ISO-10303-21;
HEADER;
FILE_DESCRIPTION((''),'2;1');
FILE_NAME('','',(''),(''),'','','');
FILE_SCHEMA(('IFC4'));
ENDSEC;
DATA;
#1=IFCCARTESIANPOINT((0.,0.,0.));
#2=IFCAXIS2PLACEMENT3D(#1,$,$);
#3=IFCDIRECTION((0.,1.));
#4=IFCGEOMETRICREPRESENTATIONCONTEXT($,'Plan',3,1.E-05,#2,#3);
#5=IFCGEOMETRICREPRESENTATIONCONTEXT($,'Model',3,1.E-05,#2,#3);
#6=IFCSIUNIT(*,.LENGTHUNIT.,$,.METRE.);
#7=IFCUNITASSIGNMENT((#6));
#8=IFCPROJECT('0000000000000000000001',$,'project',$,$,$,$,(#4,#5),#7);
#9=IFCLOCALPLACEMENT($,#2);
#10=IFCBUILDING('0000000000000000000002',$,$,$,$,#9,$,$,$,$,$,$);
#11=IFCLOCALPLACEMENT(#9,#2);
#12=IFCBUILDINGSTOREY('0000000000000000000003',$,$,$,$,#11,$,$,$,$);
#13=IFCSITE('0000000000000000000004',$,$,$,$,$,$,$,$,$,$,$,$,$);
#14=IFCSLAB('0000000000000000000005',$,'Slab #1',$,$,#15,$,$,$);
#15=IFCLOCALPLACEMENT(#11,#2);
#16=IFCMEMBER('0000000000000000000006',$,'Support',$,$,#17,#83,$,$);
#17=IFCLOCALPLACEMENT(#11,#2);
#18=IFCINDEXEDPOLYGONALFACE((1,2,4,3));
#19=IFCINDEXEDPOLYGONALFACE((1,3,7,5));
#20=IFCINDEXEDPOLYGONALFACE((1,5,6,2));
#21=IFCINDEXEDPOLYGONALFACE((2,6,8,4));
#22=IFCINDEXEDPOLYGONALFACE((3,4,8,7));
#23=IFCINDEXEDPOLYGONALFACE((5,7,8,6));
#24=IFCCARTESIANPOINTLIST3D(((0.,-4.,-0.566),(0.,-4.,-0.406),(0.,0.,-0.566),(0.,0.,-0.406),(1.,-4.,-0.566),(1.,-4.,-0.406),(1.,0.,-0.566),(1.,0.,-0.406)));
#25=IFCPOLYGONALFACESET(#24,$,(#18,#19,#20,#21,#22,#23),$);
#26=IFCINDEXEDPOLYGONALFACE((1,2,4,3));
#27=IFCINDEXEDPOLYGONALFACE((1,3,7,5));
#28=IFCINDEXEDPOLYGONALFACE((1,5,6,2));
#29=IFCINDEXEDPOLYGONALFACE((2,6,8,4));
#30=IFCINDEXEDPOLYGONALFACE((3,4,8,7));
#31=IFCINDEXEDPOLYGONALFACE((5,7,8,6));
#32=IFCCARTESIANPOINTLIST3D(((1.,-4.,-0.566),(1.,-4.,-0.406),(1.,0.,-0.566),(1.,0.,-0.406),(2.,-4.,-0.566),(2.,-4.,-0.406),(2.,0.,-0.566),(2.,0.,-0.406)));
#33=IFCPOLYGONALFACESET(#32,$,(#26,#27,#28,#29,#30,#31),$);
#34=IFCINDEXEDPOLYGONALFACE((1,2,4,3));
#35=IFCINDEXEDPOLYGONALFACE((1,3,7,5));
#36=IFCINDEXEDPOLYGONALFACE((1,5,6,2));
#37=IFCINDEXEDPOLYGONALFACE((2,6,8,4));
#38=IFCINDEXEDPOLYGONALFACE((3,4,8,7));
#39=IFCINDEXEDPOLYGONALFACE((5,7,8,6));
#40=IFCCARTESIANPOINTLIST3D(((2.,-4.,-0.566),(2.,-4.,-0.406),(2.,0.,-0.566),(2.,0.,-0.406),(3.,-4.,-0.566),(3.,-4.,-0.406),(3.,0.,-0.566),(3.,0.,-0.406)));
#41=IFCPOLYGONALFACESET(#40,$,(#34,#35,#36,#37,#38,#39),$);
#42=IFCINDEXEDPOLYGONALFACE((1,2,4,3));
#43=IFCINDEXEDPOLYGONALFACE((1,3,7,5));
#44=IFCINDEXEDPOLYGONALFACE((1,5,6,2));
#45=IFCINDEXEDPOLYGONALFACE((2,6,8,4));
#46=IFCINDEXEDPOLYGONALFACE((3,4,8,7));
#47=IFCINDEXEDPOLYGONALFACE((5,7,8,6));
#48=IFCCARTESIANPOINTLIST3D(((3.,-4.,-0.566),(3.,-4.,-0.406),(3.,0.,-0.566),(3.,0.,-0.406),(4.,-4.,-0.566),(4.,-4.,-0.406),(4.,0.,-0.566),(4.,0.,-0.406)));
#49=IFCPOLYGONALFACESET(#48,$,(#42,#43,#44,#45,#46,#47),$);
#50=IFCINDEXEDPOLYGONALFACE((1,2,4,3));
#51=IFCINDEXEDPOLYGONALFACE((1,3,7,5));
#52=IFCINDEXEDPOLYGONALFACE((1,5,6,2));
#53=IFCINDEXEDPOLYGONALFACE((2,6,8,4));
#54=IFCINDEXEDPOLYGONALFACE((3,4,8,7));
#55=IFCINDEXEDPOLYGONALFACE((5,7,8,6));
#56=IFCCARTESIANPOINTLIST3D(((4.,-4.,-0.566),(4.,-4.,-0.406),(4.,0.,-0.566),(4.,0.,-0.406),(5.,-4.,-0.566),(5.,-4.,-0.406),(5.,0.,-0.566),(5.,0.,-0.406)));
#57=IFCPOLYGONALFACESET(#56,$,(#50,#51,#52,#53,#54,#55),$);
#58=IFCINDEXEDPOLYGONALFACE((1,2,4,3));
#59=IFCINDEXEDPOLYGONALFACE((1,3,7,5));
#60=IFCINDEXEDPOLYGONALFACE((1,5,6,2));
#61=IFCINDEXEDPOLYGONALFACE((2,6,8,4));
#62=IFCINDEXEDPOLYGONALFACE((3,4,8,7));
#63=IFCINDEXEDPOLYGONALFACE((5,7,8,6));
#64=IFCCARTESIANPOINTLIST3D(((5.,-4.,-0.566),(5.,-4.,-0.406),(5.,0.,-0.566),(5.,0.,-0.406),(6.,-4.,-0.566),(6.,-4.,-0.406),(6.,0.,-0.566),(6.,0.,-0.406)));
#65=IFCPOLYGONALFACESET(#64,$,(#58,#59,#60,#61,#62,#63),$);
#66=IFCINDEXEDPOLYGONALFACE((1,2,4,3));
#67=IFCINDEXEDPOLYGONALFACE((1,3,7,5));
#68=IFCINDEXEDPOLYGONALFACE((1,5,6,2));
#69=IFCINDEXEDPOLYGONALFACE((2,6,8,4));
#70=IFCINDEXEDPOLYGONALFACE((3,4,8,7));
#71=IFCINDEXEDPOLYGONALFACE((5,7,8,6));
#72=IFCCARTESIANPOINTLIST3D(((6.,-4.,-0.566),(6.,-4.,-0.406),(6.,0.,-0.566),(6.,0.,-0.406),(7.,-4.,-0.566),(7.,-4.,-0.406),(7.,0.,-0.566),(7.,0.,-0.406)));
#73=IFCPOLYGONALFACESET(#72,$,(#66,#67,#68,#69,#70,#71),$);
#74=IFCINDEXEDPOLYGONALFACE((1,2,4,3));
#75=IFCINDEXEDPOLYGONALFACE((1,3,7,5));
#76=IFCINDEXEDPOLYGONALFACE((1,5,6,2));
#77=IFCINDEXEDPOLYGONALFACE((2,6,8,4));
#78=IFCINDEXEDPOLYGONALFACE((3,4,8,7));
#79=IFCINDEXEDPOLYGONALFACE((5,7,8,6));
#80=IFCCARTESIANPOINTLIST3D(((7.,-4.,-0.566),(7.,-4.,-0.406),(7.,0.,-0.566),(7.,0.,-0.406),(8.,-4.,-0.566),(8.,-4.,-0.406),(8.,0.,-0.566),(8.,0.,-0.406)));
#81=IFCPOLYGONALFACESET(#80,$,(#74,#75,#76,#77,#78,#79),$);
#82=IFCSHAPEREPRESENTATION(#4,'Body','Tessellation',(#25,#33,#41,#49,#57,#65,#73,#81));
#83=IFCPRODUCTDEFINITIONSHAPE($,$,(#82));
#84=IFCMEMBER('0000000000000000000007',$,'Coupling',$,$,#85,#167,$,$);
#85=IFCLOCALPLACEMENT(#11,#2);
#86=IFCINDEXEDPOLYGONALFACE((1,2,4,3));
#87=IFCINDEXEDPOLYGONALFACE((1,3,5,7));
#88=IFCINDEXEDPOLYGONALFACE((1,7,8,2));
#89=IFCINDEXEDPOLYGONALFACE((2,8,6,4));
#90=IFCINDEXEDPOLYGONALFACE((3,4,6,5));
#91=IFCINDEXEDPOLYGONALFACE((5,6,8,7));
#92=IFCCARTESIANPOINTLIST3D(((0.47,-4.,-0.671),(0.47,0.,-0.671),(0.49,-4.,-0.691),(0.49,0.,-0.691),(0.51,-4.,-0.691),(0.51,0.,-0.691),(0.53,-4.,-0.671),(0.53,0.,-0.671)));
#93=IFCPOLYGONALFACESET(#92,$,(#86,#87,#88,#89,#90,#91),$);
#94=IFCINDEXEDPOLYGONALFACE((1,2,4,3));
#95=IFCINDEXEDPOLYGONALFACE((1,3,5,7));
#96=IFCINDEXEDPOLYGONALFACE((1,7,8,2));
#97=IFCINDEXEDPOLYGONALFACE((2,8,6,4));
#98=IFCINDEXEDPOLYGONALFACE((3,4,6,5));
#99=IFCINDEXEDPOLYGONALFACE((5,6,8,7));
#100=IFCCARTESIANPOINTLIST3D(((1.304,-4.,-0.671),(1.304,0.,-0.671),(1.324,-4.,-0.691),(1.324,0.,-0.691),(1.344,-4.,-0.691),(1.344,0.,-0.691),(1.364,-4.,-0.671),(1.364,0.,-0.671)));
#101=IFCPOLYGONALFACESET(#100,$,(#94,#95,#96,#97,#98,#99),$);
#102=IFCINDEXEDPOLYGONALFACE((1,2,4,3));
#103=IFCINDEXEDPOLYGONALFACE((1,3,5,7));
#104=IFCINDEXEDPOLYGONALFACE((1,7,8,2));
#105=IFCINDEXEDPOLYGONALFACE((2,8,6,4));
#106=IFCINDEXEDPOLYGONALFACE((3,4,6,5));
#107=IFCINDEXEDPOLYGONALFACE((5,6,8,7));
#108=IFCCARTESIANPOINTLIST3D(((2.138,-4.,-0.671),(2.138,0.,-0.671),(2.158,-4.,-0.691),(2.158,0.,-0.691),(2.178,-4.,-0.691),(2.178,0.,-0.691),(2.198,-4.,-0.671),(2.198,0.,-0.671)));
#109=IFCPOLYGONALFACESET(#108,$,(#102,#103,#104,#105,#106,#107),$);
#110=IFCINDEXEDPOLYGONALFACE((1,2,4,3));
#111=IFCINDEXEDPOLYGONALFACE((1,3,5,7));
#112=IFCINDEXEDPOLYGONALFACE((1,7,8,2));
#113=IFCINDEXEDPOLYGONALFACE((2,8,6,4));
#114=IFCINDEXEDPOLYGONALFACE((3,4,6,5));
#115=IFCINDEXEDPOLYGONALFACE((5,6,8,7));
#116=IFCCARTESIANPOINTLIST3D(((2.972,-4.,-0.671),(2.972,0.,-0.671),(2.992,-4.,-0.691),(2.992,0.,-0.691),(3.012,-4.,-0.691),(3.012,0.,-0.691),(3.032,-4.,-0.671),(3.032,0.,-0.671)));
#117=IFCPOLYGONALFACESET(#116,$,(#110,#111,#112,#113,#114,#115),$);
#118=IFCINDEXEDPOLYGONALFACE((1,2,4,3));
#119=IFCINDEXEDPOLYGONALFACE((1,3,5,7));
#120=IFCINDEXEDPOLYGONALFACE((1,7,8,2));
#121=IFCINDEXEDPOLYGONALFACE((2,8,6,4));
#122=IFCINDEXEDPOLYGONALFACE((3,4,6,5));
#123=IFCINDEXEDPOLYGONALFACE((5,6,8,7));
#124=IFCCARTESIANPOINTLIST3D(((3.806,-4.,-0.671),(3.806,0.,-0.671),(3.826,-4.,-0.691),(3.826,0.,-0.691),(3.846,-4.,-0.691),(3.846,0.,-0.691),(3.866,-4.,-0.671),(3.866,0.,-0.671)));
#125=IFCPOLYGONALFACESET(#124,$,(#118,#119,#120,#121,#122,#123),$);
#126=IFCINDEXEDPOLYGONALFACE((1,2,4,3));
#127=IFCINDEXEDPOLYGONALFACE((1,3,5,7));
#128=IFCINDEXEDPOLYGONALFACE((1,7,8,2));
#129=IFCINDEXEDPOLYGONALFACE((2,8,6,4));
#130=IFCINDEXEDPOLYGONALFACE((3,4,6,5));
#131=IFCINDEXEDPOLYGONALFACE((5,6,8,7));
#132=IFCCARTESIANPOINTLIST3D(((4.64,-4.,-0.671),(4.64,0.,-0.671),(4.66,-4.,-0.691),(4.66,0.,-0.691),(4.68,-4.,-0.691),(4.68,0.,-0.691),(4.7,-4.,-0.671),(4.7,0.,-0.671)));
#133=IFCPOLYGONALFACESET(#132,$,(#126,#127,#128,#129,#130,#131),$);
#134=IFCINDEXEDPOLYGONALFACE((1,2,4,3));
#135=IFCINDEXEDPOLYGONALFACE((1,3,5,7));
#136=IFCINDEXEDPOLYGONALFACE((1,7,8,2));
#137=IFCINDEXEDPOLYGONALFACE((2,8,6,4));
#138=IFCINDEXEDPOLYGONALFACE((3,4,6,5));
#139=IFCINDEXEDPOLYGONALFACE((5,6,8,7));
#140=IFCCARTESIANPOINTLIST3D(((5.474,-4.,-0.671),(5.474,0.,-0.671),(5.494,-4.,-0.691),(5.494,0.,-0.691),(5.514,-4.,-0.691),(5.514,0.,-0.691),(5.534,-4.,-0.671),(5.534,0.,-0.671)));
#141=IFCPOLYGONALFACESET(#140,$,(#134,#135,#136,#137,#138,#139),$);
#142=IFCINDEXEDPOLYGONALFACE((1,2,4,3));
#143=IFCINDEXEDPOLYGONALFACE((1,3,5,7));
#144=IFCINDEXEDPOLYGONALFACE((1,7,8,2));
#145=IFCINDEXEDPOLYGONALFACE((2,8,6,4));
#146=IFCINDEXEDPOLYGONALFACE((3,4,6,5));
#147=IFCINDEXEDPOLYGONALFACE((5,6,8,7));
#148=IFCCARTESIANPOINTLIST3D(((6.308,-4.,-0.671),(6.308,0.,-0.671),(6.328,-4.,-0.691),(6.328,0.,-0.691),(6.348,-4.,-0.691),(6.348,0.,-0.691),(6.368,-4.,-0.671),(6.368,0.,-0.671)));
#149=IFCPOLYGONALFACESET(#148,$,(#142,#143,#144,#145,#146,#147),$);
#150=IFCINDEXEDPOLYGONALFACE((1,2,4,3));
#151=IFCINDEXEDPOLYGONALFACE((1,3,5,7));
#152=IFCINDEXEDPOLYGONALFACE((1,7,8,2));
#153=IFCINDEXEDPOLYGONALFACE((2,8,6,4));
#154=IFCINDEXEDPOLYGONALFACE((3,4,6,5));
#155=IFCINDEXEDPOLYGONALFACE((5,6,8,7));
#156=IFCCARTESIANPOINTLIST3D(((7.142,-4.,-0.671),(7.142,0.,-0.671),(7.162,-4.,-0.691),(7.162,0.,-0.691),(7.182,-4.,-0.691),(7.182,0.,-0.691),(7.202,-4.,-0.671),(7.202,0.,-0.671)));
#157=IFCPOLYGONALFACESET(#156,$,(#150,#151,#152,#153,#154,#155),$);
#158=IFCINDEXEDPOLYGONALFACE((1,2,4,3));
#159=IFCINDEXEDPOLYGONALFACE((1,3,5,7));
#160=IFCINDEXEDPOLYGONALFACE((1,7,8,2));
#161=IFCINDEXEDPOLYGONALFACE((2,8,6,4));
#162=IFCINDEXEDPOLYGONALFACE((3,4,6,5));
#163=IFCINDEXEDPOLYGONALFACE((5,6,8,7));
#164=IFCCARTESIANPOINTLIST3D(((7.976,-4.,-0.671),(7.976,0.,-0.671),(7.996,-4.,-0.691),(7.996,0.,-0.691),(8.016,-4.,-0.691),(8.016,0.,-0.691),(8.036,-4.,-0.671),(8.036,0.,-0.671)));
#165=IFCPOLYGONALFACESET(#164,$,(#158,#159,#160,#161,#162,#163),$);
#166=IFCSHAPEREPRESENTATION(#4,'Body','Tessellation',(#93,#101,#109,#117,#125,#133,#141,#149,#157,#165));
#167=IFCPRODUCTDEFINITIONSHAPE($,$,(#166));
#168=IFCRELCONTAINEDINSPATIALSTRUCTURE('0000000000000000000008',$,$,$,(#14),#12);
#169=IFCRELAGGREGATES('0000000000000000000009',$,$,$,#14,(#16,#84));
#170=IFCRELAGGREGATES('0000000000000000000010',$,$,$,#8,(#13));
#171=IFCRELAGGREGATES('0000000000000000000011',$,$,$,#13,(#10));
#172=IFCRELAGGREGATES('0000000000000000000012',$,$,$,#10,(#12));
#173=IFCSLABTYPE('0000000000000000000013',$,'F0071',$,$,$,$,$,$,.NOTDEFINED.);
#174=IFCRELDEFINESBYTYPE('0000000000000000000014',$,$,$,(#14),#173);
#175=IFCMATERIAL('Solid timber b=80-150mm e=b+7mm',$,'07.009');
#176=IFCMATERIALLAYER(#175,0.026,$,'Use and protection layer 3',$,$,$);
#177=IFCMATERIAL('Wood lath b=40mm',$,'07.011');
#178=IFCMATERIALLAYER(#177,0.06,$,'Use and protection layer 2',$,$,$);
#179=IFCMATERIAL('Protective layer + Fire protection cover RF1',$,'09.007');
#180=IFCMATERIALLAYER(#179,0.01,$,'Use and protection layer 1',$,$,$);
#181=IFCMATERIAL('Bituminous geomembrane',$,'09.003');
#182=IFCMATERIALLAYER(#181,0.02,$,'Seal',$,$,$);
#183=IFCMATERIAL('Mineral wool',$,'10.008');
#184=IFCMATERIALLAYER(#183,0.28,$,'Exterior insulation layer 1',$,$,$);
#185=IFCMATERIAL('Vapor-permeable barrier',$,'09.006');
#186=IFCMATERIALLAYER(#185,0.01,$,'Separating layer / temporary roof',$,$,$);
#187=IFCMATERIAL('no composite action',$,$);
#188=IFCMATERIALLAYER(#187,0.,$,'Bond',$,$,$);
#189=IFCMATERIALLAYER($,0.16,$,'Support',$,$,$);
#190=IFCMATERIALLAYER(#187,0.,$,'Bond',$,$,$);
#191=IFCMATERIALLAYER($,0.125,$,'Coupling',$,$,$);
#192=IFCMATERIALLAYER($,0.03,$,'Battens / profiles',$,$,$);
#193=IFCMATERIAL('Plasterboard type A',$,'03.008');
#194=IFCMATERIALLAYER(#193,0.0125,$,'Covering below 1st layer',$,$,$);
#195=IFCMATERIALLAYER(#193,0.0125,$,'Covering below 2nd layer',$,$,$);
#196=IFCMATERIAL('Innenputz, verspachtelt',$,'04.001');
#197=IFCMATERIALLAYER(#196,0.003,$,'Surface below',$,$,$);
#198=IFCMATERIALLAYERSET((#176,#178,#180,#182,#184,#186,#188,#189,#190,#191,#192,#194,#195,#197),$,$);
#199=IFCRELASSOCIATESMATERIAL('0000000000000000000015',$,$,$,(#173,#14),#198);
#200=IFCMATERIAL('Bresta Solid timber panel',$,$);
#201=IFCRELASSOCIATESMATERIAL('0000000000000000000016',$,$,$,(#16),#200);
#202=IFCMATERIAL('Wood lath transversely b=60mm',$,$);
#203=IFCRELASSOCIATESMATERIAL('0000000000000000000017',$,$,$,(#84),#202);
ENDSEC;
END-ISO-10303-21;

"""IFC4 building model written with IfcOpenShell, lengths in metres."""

from ifc_helpers import new_model, si_unit, direction, frame, frame_2d, origin, place, context, project, spatial, polyline, rectangle, outline, extrude, material, layer, layer_set, type_object, element, aggregate, save


model = new_model("IFC4")

# Units and contexts
plan_context = context("Plan", 3, precision=1e-05, world=origin(), true_north=direction((0.0, 1.0)))
model_context = context("Model", 3, precision=1e-05, world=origin(), true_north=direction((0.0, 1.0)))
ifc_project = project(units=[si_unit("LENGTHUNIT", "METRE")], contexts=[plan_context, model_context])

# Site, building, storey
site = spatial("IfcSite", under=ifc_project)
building_placement = place(None, origin())
building = spatial("IfcBuilding", under=site, at=building_placement)
storey_placement = place(building_placement, origin())
storey = spatial("IfcBuildingStorey", under=building, at=storey_placement)

# Slab, members
ifc_material_1 = material(Name="Solid timber b=80-150mm e=b+7mm", Category="07.009")
ifc_layer_1 = layer(ifc_material_1, 0.026, Name="Use and protection layer 3")
ifc_material_2 = material(Name="Wood lath b=40mm", Category="07.011")
ifc_layer_2 = layer(ifc_material_2, 0.06, Name="Use and protection layer 2")
ifc_material_3 = material(Name="Protective layer + Fire protection cover RF1", Category="09.007")
ifc_layer_3 = layer(ifc_material_3, 0.01, Name="Use and protection layer 1")
ifc_material_4 = material(Name="Bituminous geomembrane", Category="09.003")
ifc_layer_4 = layer(ifc_material_4, 0.02, Name="Seal")
ifc_material_5 = material(Name="Mineral wool", Category="10.008")
ifc_layer_5 = layer(ifc_material_5, 0.28, Name="Exterior insulation layer 1")
ifc_material_6 = material(Name="Vapor-permeable barrier", Category="09.006")
ifc_layer_6 = layer(ifc_material_6, 0.01, Name="Separating layer / temporary roof")
ifc_material_7 = material(Name="no composite action")
ifc_layer_7 = layer(ifc_material_7, 0.0, Name="Bond")
ifc_layer_8 = layer(None, 0.16, Name="Support")
ifc_layer_9 = layer(ifc_material_7, 0.0, Name="Bond")
ifc_layer_10 = layer(None, 0.125, Name="Coupling")
ifc_layer_11 = layer(None, 0.03, Name="Battens / profiles")
ifc_material_8 = material(Name="Plasterboard type A", Category="03.008")
ifc_layer_12 = layer(ifc_material_8, 0.0125, Name="Covering below 1st layer")
ifc_layer_13 = layer(ifc_material_8, 0.0125, Name="Covering below 2nd layer")
ifc_material_9 = material(Name="Innenputz, verspachtelt", Category="04.001")
ifc_layer_14 = layer(ifc_material_9, 0.003, Name="Surface below")
ifc_layer_set = layer_set([ifc_layer_1, ifc_layer_2, ifc_layer_3, ifc_layer_4, ifc_layer_5, ifc_layer_6, ifc_layer_7, ifc_layer_8, ifc_layer_9, ifc_layer_10, ifc_layer_11, ifc_layer_12, ifc_layer_13, ifc_layer_14])
slab_type = type_object("IfcSlabType", Name="F0071", PredefinedType="NOTDEFINED", material=ifc_layer_set)
slab_placement = place(None, frame((0.0, 0.0, 0.0), z_axis=(0.0, 0.0, -1.0), x_axis=(1.0, 0.0, 0.0)))
slab = element("IfcSlab", 1, at=slab_placement, inside=storey, type_object=slab_type, material=ifc_layer_set, Name="Slab #1")
ifc_material_10 = material(Name="Bresta Solid timber panel")
member_1_placement = place(slab_placement, origin())
member_1 = element("IfcMember", 2, at=member_1_placement, material=ifc_material_10, Name="Support", context=plan_context, shape_type="SweptSolid", body=[
    extrude(rectangle(XDim=1.0, YDim=0.16, at=frame_2d((0.5, 0.08), x_axis=(1.0, 0.0))), frame((0.0, 4.0, 0.406), z_axis=(0.0, -1.0, 0.0), x_axis=(1.0, 0.0, 0.0)), (0.0, 0.0, 1.0), 4.0),
    extrude(rectangle(XDim=1.0, YDim=0.16, at=frame_2d((0.5, 0.08), x_axis=(1.0, 0.0))), frame((1.0, 4.0, 0.406), z_axis=(0.0, -1.0, 0.0), x_axis=(1.0, 0.0, 0.0)), (0.0, 0.0, 1.0), 4.0),
    extrude(rectangle(XDim=1.0, YDim=0.16, at=frame_2d((0.5, 0.08), x_axis=(1.0, 0.0))), frame((2.0, 4.0, 0.406), z_axis=(0.0, -1.0, 0.0), x_axis=(1.0, 0.0, 0.0)), (0.0, 0.0, 1.0), 4.0),
    extrude(rectangle(XDim=1.0, YDim=0.16, at=frame_2d((0.5, 0.08), x_axis=(1.0, 0.0))), frame((3.0, 4.0, 0.406), z_axis=(0.0, -1.0, 0.0), x_axis=(1.0, 0.0, 0.0)), (0.0, 0.0, 1.0), 4.0),
    extrude(rectangle(XDim=1.0, YDim=0.16, at=frame_2d((0.5, 0.08), x_axis=(1.0, 0.0))), frame((4.0, 4.0, 0.406), z_axis=(0.0, -1.0, 0.0), x_axis=(1.0, 0.0, 0.0)), (0.0, 0.0, 1.0), 4.0),
    extrude(rectangle(XDim=1.0, YDim=0.16, at=frame_2d((0.5, 0.08), x_axis=(1.0, 0.0))), frame((5.0, 4.0, 0.406), z_axis=(0.0, -1.0, 0.0), x_axis=(1.0, 0.0, 0.0)), (0.0, 0.0, 1.0), 4.0),
    extrude(rectangle(XDim=1.0, YDim=0.16, at=frame_2d((0.5, 0.08), x_axis=(1.0, 0.0))), frame((6.0, 4.0, 0.406), z_axis=(0.0, -1.0, 0.0), x_axis=(1.0, 0.0, 0.0)), (0.0, 0.0, 1.0), 4.0),
    extrude(rectangle(XDim=1.0, YDim=0.16, at=frame_2d((0.5, 0.08), x_axis=(1.0, 0.0))), frame((7.0, 4.0, 0.406), z_axis=(0.0, -1.0, 0.0), x_axis=(1.0, 0.0, 0.0)), (0.0, 0.0, 1.0), 4.0),
])
ifc_material_11 = material(Name="Wood lath transversely b=60mm")
member_2_placement = place(slab_placement, origin())
member_2 = element("IfcMember", 3, at=member_2_placement, material=ifc_material_11, Name="Coupling", context=plan_context, shape_type="SweptSolid", body=[
    extrude(outline(polyline([(0.0, 0.0), (0.06, 0.0), (0.04, 0.02), (0.02, 0.02), (0.0, 0.0)])), frame((0.47, 4.0, 0.671), z_axis=(0.0, -1.0, 0.0), x_axis=(1.0, 0.0, 0.0)), (0.0, 0.0, 1.0), 4.0),
    extrude(outline(polyline([(0.0, 0.0), (0.06, 0.0), (0.04, 0.02), (0.02, 0.02), (0.0, 0.0)])), frame((1.304, 4.0, 0.671), z_axis=(0.0, -1.0, 0.0), x_axis=(1.0, 0.0, 0.0)), (0.0, 0.0, 1.0), 4.0),
    extrude(outline(polyline([(0.0, 0.0), (0.06, 0.0), (0.04, 0.02), (0.02, 0.02), (0.0, 0.0)])), frame((2.138, 4.0, 0.671), z_axis=(0.0, -1.0, 0.0), x_axis=(1.0, 0.0, 0.0)), (0.0, 0.0, 1.0), 4.0),
    extrude(outline(polyline([(0.0, 0.0), (0.06, 0.0), (0.04, 0.02), (0.02, 0.02), (0.0, 0.0)])), frame((2.972, 4.0, 0.671), z_axis=(0.0, -1.0, 0.0), x_axis=(1.0, 0.0, 0.0)), (0.0, 0.0, 1.0), 4.0),
    extrude(outline(polyline([(0.0, 0.0), (0.06, 0.0), (0.04, 0.02), (0.02, 0.02), (0.0, 0.0)])), frame((3.806, 4.0, 0.671), z_axis=(0.0, -1.0, 0.0), x_axis=(1.0, 0.0, 0.0)), (0.0, 0.0, 1.0), 4.0),
    extrude(outline(polyline([(0.0, 0.0), (0.06, 0.0), (0.04, 0.02), (0.02, 0.02), (0.0, 0.0)])), frame((4.64, 4.0, 0.671), z_axis=(0.0, -1.0, 0.0), x_axis=(1.0, 0.0, 0.0)), (0.0, 0.0, 1.0), 4.0),
    extrude(outline(polyline([(0.0, 0.0), (0.06, 0.0), (0.04, 0.02), (0.02, 0.02), (0.0, 0.0)])), frame((5.474, 4.0, 0.671), z_axis=(0.0, -1.0, 0.0), x_axis=(1.0, 0.0, 0.0)), (0.0, 0.0, 1.0), 4.0),
    extrude(outline(polyline([(0.0, 0.0), (0.06, 0.0), (0.04, 0.02), (0.02, 0.02), (0.0, 0.0)])), frame((6.308, 4.0, 0.671), z_axis=(0.0, -1.0, 0.0), x_axis=(1.0, 0.0, 0.0)), (0.0, 0.0, 1.0), 4.0),
    extrude(outline(polyline([(0.0, 0.0), (0.06, 0.0), (0.04, 0.02), (0.02, 0.02), (0.0, 0.0)])), frame((7.142, 4.0, 0.671), z_axis=(0.0, -1.0, 0.0), x_axis=(1.0, 0.0, 0.0)), (0.0, 0.0, 1.0), 4.0),
    extrude(outline(polyline([(0.0, 0.0), (0.06, 0.0), (0.04, 0.02), (0.02, 0.02), (0.0, 0.0)])), frame((7.976, 4.0, 0.671), z_axis=(0.0, -1.0, 0.0), x_axis=(1.0, 0.0, 0.0)), (0.0, 0.0, 1.0), 4.0),
])
aggregate(slab, [member_1, member_2])

save(model, "model.ifc")
